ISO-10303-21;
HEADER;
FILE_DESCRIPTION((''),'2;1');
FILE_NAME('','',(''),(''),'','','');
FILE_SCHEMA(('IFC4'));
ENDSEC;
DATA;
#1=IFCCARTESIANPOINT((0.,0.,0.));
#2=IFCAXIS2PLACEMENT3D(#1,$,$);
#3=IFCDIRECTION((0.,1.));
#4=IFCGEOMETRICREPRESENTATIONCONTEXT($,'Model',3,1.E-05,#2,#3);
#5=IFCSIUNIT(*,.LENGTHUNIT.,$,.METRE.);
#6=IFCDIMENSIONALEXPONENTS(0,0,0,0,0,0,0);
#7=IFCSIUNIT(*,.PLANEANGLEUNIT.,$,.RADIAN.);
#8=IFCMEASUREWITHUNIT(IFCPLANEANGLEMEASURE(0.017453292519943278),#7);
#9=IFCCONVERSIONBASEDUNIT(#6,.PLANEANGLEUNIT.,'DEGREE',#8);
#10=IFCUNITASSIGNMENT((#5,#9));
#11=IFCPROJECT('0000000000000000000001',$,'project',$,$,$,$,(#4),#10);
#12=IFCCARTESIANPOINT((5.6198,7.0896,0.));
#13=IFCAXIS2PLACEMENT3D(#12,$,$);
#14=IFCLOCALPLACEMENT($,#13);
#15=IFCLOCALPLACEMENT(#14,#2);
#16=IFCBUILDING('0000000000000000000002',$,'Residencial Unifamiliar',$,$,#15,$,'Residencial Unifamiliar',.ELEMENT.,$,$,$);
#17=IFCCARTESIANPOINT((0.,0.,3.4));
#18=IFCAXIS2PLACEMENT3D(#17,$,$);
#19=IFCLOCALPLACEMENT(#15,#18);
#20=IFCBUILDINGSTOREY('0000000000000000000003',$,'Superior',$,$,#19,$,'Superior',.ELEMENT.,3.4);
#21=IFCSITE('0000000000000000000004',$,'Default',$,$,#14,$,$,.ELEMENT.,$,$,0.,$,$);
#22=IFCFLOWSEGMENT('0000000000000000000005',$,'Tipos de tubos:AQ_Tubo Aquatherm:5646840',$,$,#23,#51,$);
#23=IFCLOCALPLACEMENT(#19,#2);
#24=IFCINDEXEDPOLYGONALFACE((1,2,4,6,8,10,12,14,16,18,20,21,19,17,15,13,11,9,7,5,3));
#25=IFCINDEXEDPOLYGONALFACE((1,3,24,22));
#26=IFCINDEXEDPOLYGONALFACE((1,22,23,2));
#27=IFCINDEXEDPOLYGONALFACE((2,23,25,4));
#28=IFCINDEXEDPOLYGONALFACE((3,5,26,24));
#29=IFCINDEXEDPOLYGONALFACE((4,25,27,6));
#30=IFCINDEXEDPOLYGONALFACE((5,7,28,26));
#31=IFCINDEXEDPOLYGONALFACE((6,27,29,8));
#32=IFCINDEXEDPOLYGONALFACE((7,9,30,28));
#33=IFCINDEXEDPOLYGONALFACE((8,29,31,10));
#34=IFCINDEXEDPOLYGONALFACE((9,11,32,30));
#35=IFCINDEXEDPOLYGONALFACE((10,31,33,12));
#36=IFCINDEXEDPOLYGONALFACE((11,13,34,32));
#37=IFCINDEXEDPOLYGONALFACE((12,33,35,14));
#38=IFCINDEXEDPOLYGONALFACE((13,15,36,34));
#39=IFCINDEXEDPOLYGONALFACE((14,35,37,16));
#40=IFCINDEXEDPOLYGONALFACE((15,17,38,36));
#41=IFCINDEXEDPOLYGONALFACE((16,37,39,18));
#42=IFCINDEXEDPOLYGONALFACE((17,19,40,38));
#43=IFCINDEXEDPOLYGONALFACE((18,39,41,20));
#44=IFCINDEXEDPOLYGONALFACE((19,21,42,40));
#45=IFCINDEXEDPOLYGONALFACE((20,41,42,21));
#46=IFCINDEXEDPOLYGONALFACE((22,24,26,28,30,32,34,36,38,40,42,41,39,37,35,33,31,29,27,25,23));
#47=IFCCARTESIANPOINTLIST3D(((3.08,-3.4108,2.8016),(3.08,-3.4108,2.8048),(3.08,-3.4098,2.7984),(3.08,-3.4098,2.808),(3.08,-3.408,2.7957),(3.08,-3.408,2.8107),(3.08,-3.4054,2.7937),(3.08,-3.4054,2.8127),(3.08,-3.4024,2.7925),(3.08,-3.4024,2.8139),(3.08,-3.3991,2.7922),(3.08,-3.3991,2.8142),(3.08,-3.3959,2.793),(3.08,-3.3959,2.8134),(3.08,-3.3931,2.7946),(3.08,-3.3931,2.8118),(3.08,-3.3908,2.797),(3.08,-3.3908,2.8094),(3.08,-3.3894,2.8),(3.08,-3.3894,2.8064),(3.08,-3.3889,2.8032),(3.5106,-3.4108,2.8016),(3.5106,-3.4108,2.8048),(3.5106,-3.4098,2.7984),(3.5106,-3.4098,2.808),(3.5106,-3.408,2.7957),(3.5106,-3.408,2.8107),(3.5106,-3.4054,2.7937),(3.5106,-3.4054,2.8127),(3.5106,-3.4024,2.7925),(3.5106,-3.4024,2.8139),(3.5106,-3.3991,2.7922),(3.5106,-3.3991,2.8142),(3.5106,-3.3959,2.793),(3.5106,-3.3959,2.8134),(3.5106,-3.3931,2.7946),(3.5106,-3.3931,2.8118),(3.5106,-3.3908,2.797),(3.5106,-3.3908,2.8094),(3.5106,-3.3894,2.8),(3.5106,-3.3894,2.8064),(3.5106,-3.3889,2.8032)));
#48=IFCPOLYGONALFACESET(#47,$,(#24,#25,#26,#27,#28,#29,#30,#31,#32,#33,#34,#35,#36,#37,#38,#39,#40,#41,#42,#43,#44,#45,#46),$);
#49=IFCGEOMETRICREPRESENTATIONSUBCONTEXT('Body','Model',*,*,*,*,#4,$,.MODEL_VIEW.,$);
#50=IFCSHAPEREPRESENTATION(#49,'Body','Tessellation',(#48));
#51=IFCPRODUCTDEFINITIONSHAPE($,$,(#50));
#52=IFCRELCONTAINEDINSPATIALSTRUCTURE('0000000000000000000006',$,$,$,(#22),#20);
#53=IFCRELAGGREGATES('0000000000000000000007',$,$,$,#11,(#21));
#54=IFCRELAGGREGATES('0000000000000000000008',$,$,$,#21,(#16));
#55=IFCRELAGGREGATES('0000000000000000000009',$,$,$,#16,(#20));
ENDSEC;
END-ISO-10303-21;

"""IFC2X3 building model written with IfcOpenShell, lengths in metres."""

from ifc_helpers import new_model, entity, si_unit, converted_unit, direction, frame, origin, origin_2d_with_axis, place, context, subcontext, project, spatial, circle, extrude, element, save


model = new_model("IFC2X3")

# Units and contexts
model_context = context("Model", 3, precision=1e-05, world=origin(), true_north=direction((0.0, 1.0)))
body_context = subcontext(model_context, "Body", "Model", "MODEL_VIEW")
ifc_project = project(units=[si_unit("LENGTHUNIT", "METRE"), converted_unit("PLANEANGLEUNIT", "DEGREE", entity("IfcPlaneAngleMeasure", 0.017453292519943278), si_unit("PLANEANGLEUNIT", "RADIAN"), dimensions=[0, 0, 0, 0, 0, 0, 0])], contexts=[model_context])

# Site, building, storey
site_placement = place(None, frame((5.6198, 7.0896, 0.0)))
site = spatial("IfcSite", under=ifc_project, at=site_placement, Name="Default", CompositionType="ELEMENT", RefElevation=0.0)
building_placement = place(site_placement, origin())
building = spatial("IfcBuilding", under=site, at=building_placement, Name="Residencial Unifamiliar", LongName="Residencial Unifamiliar", CompositionType="ELEMENT")
storey_placement = place(building_placement, frame((0.0, 0.0, 3.4)))
storey = spatial("IfcBuildingStorey", under=building, at=storey_placement, Name="Superior", LongName="Superior", CompositionType="ELEMENT", Elevation=3.4)

# Flow segment
flow_segment_1_placement = place(storey_placement, origin())
element("IfcFlowSegment", 1, at=flow_segment_1_placement, inside=storey, Name="Tipos de tubos:AQ_Tubo Aquatherm:5646840", context=body_context, shape_type="SweptSolid", body=[
    extrude(circle(Radius=0.011, at=origin_2d_with_axis()), frame((3.08, -3.3999, 2.8032), z_axis=(1.0, -0.000011, 0.0), x_axis=(0.000011, 1.0, 0.0)), (0.0, 0.0, 1.0), 0.4306),
])

save(model, "model.ifc")
